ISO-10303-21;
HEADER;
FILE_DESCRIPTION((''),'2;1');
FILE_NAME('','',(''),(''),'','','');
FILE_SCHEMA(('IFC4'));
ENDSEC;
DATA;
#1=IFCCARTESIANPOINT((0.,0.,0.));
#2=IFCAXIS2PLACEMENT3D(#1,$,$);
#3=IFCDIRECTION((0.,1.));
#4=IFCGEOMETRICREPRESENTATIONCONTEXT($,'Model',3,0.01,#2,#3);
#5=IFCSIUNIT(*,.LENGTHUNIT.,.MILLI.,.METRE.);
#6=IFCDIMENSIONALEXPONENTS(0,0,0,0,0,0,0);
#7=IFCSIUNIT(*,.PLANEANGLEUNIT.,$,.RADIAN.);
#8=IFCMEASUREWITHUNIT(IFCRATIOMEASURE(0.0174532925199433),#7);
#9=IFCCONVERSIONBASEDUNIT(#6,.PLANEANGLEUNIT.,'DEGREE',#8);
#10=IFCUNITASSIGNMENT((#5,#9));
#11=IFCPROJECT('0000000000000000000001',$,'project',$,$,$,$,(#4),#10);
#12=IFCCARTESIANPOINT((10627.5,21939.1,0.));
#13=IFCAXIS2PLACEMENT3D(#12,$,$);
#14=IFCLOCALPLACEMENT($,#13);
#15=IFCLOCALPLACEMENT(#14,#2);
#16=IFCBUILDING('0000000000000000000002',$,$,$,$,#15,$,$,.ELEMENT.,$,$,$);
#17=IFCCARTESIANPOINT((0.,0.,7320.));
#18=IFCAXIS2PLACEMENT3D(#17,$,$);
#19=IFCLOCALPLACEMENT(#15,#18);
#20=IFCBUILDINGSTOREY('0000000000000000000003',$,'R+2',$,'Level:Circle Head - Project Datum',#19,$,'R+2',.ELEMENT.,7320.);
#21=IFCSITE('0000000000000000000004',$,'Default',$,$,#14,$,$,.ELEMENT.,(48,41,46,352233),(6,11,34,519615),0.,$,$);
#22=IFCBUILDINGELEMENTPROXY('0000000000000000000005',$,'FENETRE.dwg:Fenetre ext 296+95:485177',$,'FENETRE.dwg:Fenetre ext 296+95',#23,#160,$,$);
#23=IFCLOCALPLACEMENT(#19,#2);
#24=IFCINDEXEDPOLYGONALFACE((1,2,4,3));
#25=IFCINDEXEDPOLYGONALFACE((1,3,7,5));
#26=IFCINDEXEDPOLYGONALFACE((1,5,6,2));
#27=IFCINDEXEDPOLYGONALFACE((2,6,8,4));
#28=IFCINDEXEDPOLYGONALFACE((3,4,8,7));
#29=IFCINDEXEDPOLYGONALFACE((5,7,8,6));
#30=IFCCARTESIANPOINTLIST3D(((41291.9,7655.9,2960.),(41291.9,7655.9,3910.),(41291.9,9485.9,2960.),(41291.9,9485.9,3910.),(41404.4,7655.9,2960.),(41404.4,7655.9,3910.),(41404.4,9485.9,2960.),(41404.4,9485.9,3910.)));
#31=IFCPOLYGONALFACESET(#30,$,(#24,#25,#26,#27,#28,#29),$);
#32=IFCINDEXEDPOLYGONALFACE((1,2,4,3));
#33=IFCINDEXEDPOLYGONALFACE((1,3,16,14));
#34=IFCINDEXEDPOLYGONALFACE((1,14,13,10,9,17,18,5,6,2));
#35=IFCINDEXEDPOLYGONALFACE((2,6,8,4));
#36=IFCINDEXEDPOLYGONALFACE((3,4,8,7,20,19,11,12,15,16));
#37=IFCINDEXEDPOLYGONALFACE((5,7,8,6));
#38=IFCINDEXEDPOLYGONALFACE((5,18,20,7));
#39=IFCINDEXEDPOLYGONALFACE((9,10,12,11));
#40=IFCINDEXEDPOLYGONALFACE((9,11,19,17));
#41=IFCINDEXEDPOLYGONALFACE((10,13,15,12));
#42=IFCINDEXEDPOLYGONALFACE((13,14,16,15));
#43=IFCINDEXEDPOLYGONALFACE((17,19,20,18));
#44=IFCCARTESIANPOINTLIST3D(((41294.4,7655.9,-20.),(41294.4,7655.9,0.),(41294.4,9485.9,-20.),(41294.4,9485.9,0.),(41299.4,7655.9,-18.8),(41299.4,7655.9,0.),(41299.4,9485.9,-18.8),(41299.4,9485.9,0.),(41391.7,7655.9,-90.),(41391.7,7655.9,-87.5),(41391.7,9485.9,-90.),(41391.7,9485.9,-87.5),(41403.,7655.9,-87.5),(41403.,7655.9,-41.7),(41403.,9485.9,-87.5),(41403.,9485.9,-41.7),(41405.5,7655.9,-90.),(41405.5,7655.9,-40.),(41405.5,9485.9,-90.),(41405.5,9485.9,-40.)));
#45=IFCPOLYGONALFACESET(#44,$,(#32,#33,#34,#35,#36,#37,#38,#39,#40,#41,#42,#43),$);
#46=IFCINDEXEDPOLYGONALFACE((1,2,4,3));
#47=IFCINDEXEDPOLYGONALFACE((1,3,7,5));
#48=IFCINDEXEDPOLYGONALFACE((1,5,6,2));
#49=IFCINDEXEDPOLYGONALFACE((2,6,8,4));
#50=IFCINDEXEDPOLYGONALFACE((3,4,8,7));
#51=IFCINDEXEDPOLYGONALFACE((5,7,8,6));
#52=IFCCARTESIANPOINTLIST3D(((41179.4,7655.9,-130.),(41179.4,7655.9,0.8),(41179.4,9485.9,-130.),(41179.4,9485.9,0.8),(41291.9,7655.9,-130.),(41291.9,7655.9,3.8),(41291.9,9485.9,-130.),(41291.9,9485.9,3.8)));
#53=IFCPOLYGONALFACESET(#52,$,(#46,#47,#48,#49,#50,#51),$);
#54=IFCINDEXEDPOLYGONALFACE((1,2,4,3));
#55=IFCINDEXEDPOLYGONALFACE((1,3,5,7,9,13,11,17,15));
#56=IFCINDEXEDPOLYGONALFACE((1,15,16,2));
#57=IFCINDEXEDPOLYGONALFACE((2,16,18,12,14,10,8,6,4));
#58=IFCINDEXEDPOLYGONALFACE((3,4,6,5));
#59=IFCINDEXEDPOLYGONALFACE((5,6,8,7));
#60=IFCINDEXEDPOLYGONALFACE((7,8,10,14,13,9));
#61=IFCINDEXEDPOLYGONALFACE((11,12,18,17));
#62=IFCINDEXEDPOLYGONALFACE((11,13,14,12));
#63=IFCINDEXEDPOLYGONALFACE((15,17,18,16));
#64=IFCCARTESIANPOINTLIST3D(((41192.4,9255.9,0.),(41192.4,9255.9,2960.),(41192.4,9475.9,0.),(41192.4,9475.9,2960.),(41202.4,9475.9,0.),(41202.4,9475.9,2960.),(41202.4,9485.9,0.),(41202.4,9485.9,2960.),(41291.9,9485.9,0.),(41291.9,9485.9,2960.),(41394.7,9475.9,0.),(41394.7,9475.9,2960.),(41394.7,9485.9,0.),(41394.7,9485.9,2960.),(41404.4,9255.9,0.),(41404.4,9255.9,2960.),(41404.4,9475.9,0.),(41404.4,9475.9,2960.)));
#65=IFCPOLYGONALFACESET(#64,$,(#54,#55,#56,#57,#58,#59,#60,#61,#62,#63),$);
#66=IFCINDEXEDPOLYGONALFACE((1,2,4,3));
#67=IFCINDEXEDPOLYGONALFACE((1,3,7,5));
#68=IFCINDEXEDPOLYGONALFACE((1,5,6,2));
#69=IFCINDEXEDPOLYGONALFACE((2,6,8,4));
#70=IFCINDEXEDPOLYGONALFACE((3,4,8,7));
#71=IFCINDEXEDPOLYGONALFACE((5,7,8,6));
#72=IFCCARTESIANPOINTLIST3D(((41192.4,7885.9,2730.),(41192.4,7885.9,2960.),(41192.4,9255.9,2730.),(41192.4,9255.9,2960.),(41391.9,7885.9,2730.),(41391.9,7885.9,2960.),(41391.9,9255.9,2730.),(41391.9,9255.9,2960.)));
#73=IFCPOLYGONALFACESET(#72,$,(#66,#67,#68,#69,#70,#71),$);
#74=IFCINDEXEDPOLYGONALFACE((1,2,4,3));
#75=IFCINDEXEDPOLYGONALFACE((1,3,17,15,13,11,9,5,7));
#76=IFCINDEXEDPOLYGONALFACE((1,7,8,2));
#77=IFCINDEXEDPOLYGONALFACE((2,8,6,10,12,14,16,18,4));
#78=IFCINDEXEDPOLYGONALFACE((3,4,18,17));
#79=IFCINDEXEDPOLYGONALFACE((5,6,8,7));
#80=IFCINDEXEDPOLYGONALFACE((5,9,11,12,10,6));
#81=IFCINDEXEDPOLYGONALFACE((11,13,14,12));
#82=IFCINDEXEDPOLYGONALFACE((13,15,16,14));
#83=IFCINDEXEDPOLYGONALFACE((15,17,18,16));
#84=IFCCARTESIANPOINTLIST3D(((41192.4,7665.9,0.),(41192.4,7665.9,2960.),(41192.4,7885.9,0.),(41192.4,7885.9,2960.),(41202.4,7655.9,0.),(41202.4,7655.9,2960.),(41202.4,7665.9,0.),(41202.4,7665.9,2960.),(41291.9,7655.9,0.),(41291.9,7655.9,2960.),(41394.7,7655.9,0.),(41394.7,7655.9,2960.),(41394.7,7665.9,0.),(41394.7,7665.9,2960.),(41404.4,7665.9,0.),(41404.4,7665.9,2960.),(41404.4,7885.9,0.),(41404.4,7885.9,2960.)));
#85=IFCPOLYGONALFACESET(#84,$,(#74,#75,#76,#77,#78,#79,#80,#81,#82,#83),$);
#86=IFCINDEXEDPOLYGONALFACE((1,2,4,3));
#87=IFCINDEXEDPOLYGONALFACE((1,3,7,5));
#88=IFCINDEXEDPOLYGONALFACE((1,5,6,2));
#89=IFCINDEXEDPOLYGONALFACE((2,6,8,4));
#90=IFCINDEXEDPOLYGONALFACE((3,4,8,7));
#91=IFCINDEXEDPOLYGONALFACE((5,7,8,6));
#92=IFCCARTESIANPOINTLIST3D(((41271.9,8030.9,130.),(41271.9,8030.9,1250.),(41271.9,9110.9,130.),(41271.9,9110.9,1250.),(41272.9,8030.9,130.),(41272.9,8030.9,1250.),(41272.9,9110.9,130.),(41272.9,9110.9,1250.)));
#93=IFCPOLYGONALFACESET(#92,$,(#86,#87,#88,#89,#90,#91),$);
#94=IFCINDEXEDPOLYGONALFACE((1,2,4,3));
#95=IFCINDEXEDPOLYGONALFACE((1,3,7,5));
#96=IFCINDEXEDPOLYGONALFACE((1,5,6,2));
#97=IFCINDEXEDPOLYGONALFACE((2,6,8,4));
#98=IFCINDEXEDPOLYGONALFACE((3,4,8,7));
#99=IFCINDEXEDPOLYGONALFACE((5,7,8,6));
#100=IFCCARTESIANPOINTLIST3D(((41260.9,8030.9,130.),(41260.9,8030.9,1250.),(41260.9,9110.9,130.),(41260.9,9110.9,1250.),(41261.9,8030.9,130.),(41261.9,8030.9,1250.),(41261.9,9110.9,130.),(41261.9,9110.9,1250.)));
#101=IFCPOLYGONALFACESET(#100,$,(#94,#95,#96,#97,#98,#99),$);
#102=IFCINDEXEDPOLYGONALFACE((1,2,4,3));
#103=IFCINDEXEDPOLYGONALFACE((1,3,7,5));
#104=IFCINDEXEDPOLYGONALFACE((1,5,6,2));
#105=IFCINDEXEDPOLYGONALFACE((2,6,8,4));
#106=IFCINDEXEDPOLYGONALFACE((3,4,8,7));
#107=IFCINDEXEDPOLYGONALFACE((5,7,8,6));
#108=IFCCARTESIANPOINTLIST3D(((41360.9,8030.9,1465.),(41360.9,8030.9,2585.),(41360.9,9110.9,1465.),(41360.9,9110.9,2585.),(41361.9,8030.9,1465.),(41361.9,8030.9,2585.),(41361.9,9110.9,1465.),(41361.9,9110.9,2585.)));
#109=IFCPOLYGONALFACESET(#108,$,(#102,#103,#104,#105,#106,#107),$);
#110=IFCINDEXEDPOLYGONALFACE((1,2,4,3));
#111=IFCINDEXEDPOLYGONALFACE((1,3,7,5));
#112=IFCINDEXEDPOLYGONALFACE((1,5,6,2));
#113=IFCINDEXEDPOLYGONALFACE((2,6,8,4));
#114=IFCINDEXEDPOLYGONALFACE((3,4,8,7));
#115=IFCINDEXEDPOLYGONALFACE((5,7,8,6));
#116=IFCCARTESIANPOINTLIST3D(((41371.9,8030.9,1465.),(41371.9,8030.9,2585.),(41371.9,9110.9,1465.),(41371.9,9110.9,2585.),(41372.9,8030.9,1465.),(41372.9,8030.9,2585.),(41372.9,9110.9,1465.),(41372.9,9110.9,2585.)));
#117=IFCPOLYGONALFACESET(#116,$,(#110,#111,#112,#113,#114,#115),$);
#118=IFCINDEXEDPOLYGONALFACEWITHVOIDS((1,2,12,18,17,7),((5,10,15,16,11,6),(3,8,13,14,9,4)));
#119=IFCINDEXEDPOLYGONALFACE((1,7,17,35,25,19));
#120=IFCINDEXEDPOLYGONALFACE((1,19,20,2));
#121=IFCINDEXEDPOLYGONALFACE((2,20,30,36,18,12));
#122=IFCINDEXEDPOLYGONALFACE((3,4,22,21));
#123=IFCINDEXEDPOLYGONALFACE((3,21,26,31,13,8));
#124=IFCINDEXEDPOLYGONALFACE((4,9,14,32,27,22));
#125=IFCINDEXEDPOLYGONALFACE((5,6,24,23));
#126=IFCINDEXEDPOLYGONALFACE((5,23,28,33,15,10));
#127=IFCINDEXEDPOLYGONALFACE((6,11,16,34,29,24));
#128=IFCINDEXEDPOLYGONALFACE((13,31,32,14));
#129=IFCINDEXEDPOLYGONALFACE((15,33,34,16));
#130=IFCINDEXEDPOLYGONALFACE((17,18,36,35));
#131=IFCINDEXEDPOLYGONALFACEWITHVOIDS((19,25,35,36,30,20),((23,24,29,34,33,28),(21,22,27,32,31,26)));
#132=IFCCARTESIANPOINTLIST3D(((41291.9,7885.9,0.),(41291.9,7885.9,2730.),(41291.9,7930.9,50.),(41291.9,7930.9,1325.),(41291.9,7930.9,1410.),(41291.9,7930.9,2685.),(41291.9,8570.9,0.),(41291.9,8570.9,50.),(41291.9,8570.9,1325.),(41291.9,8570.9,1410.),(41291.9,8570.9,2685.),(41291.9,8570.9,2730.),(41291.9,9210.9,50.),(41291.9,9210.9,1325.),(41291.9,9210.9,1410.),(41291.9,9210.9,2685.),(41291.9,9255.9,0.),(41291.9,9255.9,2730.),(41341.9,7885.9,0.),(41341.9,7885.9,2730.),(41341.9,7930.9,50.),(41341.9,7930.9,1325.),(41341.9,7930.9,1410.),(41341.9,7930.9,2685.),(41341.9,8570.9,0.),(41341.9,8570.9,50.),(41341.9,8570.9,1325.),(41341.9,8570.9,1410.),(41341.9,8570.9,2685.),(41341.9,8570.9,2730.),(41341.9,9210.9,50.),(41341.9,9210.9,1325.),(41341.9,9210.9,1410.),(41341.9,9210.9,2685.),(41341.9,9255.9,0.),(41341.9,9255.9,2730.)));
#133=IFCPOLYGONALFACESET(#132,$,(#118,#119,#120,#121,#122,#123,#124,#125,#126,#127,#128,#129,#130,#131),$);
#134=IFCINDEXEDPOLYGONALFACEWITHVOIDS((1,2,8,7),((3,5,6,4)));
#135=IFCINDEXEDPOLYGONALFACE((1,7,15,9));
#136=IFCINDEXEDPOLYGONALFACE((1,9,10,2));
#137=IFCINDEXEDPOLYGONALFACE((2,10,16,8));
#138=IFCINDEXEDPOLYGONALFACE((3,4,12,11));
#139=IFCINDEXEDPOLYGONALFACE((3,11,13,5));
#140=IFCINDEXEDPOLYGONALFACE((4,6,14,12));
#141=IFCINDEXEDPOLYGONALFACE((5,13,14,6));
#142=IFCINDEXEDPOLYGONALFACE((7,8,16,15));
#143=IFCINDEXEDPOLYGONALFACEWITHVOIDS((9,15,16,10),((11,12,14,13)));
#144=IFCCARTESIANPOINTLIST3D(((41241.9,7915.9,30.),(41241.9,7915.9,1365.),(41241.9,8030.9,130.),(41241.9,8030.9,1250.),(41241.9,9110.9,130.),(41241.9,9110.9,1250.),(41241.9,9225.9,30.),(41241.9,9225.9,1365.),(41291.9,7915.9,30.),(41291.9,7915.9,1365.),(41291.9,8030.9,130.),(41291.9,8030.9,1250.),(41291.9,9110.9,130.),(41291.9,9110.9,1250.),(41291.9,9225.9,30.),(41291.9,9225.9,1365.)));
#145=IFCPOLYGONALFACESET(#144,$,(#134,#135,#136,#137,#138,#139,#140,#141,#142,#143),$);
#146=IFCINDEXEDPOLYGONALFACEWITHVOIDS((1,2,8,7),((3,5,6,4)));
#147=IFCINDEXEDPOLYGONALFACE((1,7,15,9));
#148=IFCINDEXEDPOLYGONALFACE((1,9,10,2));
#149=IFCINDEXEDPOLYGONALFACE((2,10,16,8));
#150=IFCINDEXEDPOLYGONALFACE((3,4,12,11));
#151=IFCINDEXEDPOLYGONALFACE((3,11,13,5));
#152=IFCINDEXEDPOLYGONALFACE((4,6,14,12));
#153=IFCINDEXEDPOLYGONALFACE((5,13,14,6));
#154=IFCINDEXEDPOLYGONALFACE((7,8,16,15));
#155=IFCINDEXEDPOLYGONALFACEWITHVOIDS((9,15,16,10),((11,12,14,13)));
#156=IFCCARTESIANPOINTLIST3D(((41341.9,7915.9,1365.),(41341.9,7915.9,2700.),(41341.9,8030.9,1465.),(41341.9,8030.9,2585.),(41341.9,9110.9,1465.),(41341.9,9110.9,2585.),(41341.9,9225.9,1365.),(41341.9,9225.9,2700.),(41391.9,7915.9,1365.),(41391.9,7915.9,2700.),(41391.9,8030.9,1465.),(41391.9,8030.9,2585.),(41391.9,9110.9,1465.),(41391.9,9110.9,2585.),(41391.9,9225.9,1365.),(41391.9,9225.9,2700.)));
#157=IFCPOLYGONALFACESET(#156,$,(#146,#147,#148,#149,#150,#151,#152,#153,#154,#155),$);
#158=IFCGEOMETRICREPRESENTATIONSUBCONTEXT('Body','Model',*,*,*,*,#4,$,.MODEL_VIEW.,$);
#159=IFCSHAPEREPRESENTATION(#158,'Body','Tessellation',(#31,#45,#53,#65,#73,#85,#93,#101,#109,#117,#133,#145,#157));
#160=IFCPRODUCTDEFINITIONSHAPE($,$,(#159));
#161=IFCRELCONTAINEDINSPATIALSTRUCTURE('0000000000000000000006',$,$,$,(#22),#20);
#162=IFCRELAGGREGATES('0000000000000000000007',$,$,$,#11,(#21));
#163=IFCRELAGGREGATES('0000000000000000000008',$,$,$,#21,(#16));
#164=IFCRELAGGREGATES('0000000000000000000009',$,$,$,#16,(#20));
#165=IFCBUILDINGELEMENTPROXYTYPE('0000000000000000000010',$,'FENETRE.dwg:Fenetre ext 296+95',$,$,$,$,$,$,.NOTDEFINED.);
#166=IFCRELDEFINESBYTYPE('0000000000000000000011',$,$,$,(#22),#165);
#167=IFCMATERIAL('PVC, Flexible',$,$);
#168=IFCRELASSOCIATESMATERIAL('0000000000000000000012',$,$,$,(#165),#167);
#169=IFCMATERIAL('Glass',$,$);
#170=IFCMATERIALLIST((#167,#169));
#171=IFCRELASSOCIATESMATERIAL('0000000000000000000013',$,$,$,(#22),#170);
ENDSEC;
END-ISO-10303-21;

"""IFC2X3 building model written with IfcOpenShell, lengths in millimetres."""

from ifc_helpers import new_model, entity, si_unit, converted_unit, direction, frame, frame_2d, origin, origin_2d_with_axis, place, context, subcontext, project, spatial, polyline, rectangle, outline, extrude, source, transform, mapped, material, material_list, type_object, type_shapes, element, save


model = new_model("IFC2X3")

# Units and contexts
model_context = context("Model", 3, precision=0.01, world=origin(), true_north=direction((0.0, 1.0)))
body_context = subcontext(model_context, "Body", "Model", "MODEL_VIEW")
ifc_project = project(units=[si_unit("LENGTHUNIT", "METRE", prefix="MILLI"), converted_unit("PLANEANGLEUNIT", "DEGREE", entity("IfcRatioMeasure", 0.0174532925199433), si_unit("PLANEANGLEUNIT", "RADIAN"), dimensions=[0, 0, 0, 0, 0, 0, 0])], contexts=[model_context])

# Site, building, storey
site_placement = place(None, frame((10627.5, 21939.1, 0.0)))
site = spatial("IfcSite", under=ifc_project, at=site_placement, Name="Default", CompositionType="ELEMENT", RefLatitude=(48, 41, 46, 352233), RefLongitude=(6, 11, 34, 519615), RefElevation=0.0)
building_placement = place(site_placement, origin())
building = spatial("IfcBuilding", under=site, at=building_placement, CompositionType="ELEMENT")
storey_placement = place(building_placement, frame((0.0, 0.0, 7320.0)))
storey = spatial("IfcBuildingStorey", under=building, at=storey_placement, Name="R+2", ObjectType="Level:Circle Head - Project Datum", LongName="R+2", CompositionType="ELEMENT", Elevation=7320.0)

# Building element proxy
ifc_material_1 = material(Name="PVC, Flexible")
ifc_material_2 = material(Name="Glass")
building_element_proxy_type_1 = type_object("IfcBuildingElementProxyType", Name="FENETRE.dwg:Fenetre ext 296+95", PredefinedType="NOTDEFINED", material=ifc_material_1)
shared_shape_1 = source(origin(), body_context, "Body", "SweptSolid", [
    extrude(rectangle(XDim=112.5, YDim=1830.0, at=origin_2d_with_axis()), frame((-10.4, -56.3, 2960.0), z_axis=(0.0, 0.0, 1.0), x_axis=(0.0, 1.0, 0.0)), (0.0, 0.0, 1.0), 950.0),
    extrude(outline(polyline([(27.5, -64.4), (47.5, -64.4), (47.5, -59.4), (28.8, -59.4), (7.5, 46.7), (-42.5, 46.7), (-42.5, 32.9), (-40.0, 32.9), (-40.0, 44.2), (5.8, 44.2), (27.5, -64.4)])), frame((-925.4, -66.9, -47.5), z_axis=(1.0, 0.0, 0.0), x_axis=(0.0, 0.0, 1.0)), (0.0, 0.0, 1.0), 1830.0),
    extrude(outline(polyline([(-54.5, -66.1), (58.0, -66.1), (54.5, 67.6), (-58.0, 64.6), (-54.5, -66.1)])), frame((-925.4, 56.3, -63.8), z_axis=(1.0, 0.0, 0.0), x_axis=(0.0, -0.999645, 0.02665)), (0.0, 0.0, 1.0), 1830.0),
    extrude(outline(polyline([(-97.0, -55.6), (5.9, -55.6), (95.4, -55.6), (95.4, -45.6), (105.4, -45.6), (105.4, 174.4), (-106.6, 174.4), (-106.6, -45.6), (-97.0, -45.6), (-97.0, -55.6)])), frame((849.0, -5.9, 0.0), z_axis=(0.0, 0.0, 1.0), x_axis=(0.0, 1.0, 0.0)), (0.0, 0.0, 1.0), 2960.0),
    extrude(rectangle(XDim=1370.0, YDim=199.5, at=origin_2d_with_axis()), frame((-10.4, -0.3, 2730.0), z_axis=(0.0, 0.0, 1.0), x_axis=(-1.0, 0.0, 0.0)), (0.0, 0.0, 1.0), 230.0),
    extrude(outline(polyline([(-55.6, 97.0), (-55.6, -5.9), (-55.6, -95.4), (-45.6, -95.4), (-45.6, -105.4), (174.4, -105.4), (174.4, 106.6), (-45.6, 106.6), (-45.6, 97.0), (-55.6, 97.0)])), frame((-869.9, -5.9, 0.0), z_axis=(0.0, 0.0, -1.0), x_axis=(1.0, 0.0, 0.0)), (0.0, 0.0, -1.0), 2960.0),
    extrude(rectangle(XDim=1080.0, YDim=1.0, at=origin_2d_with_axis()), frame((-10.4, 19.5, 130.0), z_axis=(0.0, 0.0, 1.0), x_axis=(-1.0, 0.0, 0.0)), (0.0, 0.0, 1.0), 1120.0),
    extrude(rectangle(XDim=1080.0, YDim=1.0, at=origin_2d_with_axis()), frame((-10.4, 30.5, 130.0), z_axis=(0.0, 0.0, 1.0), x_axis=(-1.0, 0.0, 0.0)), (0.0, 0.0, 1.0), 1120.0),
    extrude(rectangle(XDim=1080.0, YDim=1.0, at=frame_2d((0.0, 0.0), x_axis=(1.0, 0.0))), frame((-10.4, -69.5, 1465.0), z_axis=(0.0, 0.0, 1.0), x_axis=(-1.0, 0.0, 0.0)), (0.0, 0.0, 1.0), 1120.0),
    extrude(rectangle(XDim=1080.0, YDim=1.0, at=frame_2d((0.0, 0.0), x_axis=(1.0, 0.0))), frame((-10.4, -80.5, 1465.0), z_axis=(0.0, 0.0, 1.0), x_axis=(-1.0, 0.0, 0.0)), (0.0, 0.0, 1.0), 1120.0),
    extrude(outline(polyline([(-685.0, -1365.0), (0.0, -1365.0), (685.0, -1365.0), (685.0, 1365.0), (0.0, 1365.0), (-685.0, 1365.0), (-685.0, -1365.0)]), holes=[polyline([(-640.0, -1320.0), (-640.0, -45.0), (0.0, -45.0), (640.0, -45.0), (640.0, -1320.0), (0.0, -1320.0), (-640.0, -1320.0)]), polyline([(-640.0, 40.0), (-640.0, 1315.0), (0.0, 1315.0), (640.0, 1315.0), (640.0, 40.0), (0.0, 40.0), (-640.0, 40.0)])]), frame((-10.4, -50.0, 1365.0), z_axis=(0.0, 1.0, 0.0), x_axis=(1.0, 0.0, 0.0)), (0.0, 0.0, 1.0), 50.0),
    extrude(outline(polyline([(-655.0, -667.5), (655.0, -667.5), (655.0, 667.5), (-655.0, 667.5), (-655.0, -667.5)]), holes=[polyline([(-540.0, 552.5), (540.0, 552.5), (540.0, -567.5), (-540.0, -567.5), (-540.0, 552.5)])]), frame((-10.4, 0.0, 697.5), z_axis=(0.0, 1.0, 0.0), x_axis=(-1.0, 0.0, 0.0)), (0.0, 0.0, 1.0), 50.0),
    extrude(outline(polyline([(-655.0, -667.5), (655.0, -667.5), (655.0, 667.5), (-655.0, 667.5), (-655.0, -667.5)]), holes=[polyline([(-540.0, 552.5), (540.0, 552.5), (540.0, -567.5), (-540.0, -567.5), (-540.0, 552.5)])]), frame((-10.4, -100.0, 2032.5), z_axis=(0.0, 1.0, 0.0), x_axis=(-1.0, 0.0, 0.0)), (0.0, 0.0, 1.0), 50.0),
])
type_shapes(building_element_proxy_type_1, [shared_shape_1])
ifc_material_list_1 = material_list([ifc_material_1, ifc_material_2])
proxy_1_placement = place(storey_placement, frame((41291.9, 8581.3, 0.0), z_axis=(0.0, 0.0, 1.0), x_axis=(0.0, 1.0, 0.0)))
element("IfcBuildingElementProxy", 1, at=proxy_1_placement, inside=storey, type_object=building_element_proxy_type_1, material=ifc_material_list_1, Name="FENETRE.dwg:Fenetre ext 296+95:485177", ObjectType="FENETRE.dwg:Fenetre ext 296+95", context=body_context, shape_type="MappedRepresentation", body=[
    mapped(shared_shape_1, transform((0.0, 0.0, 0.0), scale=1.0)),
])

save(model, "model.ifc")
